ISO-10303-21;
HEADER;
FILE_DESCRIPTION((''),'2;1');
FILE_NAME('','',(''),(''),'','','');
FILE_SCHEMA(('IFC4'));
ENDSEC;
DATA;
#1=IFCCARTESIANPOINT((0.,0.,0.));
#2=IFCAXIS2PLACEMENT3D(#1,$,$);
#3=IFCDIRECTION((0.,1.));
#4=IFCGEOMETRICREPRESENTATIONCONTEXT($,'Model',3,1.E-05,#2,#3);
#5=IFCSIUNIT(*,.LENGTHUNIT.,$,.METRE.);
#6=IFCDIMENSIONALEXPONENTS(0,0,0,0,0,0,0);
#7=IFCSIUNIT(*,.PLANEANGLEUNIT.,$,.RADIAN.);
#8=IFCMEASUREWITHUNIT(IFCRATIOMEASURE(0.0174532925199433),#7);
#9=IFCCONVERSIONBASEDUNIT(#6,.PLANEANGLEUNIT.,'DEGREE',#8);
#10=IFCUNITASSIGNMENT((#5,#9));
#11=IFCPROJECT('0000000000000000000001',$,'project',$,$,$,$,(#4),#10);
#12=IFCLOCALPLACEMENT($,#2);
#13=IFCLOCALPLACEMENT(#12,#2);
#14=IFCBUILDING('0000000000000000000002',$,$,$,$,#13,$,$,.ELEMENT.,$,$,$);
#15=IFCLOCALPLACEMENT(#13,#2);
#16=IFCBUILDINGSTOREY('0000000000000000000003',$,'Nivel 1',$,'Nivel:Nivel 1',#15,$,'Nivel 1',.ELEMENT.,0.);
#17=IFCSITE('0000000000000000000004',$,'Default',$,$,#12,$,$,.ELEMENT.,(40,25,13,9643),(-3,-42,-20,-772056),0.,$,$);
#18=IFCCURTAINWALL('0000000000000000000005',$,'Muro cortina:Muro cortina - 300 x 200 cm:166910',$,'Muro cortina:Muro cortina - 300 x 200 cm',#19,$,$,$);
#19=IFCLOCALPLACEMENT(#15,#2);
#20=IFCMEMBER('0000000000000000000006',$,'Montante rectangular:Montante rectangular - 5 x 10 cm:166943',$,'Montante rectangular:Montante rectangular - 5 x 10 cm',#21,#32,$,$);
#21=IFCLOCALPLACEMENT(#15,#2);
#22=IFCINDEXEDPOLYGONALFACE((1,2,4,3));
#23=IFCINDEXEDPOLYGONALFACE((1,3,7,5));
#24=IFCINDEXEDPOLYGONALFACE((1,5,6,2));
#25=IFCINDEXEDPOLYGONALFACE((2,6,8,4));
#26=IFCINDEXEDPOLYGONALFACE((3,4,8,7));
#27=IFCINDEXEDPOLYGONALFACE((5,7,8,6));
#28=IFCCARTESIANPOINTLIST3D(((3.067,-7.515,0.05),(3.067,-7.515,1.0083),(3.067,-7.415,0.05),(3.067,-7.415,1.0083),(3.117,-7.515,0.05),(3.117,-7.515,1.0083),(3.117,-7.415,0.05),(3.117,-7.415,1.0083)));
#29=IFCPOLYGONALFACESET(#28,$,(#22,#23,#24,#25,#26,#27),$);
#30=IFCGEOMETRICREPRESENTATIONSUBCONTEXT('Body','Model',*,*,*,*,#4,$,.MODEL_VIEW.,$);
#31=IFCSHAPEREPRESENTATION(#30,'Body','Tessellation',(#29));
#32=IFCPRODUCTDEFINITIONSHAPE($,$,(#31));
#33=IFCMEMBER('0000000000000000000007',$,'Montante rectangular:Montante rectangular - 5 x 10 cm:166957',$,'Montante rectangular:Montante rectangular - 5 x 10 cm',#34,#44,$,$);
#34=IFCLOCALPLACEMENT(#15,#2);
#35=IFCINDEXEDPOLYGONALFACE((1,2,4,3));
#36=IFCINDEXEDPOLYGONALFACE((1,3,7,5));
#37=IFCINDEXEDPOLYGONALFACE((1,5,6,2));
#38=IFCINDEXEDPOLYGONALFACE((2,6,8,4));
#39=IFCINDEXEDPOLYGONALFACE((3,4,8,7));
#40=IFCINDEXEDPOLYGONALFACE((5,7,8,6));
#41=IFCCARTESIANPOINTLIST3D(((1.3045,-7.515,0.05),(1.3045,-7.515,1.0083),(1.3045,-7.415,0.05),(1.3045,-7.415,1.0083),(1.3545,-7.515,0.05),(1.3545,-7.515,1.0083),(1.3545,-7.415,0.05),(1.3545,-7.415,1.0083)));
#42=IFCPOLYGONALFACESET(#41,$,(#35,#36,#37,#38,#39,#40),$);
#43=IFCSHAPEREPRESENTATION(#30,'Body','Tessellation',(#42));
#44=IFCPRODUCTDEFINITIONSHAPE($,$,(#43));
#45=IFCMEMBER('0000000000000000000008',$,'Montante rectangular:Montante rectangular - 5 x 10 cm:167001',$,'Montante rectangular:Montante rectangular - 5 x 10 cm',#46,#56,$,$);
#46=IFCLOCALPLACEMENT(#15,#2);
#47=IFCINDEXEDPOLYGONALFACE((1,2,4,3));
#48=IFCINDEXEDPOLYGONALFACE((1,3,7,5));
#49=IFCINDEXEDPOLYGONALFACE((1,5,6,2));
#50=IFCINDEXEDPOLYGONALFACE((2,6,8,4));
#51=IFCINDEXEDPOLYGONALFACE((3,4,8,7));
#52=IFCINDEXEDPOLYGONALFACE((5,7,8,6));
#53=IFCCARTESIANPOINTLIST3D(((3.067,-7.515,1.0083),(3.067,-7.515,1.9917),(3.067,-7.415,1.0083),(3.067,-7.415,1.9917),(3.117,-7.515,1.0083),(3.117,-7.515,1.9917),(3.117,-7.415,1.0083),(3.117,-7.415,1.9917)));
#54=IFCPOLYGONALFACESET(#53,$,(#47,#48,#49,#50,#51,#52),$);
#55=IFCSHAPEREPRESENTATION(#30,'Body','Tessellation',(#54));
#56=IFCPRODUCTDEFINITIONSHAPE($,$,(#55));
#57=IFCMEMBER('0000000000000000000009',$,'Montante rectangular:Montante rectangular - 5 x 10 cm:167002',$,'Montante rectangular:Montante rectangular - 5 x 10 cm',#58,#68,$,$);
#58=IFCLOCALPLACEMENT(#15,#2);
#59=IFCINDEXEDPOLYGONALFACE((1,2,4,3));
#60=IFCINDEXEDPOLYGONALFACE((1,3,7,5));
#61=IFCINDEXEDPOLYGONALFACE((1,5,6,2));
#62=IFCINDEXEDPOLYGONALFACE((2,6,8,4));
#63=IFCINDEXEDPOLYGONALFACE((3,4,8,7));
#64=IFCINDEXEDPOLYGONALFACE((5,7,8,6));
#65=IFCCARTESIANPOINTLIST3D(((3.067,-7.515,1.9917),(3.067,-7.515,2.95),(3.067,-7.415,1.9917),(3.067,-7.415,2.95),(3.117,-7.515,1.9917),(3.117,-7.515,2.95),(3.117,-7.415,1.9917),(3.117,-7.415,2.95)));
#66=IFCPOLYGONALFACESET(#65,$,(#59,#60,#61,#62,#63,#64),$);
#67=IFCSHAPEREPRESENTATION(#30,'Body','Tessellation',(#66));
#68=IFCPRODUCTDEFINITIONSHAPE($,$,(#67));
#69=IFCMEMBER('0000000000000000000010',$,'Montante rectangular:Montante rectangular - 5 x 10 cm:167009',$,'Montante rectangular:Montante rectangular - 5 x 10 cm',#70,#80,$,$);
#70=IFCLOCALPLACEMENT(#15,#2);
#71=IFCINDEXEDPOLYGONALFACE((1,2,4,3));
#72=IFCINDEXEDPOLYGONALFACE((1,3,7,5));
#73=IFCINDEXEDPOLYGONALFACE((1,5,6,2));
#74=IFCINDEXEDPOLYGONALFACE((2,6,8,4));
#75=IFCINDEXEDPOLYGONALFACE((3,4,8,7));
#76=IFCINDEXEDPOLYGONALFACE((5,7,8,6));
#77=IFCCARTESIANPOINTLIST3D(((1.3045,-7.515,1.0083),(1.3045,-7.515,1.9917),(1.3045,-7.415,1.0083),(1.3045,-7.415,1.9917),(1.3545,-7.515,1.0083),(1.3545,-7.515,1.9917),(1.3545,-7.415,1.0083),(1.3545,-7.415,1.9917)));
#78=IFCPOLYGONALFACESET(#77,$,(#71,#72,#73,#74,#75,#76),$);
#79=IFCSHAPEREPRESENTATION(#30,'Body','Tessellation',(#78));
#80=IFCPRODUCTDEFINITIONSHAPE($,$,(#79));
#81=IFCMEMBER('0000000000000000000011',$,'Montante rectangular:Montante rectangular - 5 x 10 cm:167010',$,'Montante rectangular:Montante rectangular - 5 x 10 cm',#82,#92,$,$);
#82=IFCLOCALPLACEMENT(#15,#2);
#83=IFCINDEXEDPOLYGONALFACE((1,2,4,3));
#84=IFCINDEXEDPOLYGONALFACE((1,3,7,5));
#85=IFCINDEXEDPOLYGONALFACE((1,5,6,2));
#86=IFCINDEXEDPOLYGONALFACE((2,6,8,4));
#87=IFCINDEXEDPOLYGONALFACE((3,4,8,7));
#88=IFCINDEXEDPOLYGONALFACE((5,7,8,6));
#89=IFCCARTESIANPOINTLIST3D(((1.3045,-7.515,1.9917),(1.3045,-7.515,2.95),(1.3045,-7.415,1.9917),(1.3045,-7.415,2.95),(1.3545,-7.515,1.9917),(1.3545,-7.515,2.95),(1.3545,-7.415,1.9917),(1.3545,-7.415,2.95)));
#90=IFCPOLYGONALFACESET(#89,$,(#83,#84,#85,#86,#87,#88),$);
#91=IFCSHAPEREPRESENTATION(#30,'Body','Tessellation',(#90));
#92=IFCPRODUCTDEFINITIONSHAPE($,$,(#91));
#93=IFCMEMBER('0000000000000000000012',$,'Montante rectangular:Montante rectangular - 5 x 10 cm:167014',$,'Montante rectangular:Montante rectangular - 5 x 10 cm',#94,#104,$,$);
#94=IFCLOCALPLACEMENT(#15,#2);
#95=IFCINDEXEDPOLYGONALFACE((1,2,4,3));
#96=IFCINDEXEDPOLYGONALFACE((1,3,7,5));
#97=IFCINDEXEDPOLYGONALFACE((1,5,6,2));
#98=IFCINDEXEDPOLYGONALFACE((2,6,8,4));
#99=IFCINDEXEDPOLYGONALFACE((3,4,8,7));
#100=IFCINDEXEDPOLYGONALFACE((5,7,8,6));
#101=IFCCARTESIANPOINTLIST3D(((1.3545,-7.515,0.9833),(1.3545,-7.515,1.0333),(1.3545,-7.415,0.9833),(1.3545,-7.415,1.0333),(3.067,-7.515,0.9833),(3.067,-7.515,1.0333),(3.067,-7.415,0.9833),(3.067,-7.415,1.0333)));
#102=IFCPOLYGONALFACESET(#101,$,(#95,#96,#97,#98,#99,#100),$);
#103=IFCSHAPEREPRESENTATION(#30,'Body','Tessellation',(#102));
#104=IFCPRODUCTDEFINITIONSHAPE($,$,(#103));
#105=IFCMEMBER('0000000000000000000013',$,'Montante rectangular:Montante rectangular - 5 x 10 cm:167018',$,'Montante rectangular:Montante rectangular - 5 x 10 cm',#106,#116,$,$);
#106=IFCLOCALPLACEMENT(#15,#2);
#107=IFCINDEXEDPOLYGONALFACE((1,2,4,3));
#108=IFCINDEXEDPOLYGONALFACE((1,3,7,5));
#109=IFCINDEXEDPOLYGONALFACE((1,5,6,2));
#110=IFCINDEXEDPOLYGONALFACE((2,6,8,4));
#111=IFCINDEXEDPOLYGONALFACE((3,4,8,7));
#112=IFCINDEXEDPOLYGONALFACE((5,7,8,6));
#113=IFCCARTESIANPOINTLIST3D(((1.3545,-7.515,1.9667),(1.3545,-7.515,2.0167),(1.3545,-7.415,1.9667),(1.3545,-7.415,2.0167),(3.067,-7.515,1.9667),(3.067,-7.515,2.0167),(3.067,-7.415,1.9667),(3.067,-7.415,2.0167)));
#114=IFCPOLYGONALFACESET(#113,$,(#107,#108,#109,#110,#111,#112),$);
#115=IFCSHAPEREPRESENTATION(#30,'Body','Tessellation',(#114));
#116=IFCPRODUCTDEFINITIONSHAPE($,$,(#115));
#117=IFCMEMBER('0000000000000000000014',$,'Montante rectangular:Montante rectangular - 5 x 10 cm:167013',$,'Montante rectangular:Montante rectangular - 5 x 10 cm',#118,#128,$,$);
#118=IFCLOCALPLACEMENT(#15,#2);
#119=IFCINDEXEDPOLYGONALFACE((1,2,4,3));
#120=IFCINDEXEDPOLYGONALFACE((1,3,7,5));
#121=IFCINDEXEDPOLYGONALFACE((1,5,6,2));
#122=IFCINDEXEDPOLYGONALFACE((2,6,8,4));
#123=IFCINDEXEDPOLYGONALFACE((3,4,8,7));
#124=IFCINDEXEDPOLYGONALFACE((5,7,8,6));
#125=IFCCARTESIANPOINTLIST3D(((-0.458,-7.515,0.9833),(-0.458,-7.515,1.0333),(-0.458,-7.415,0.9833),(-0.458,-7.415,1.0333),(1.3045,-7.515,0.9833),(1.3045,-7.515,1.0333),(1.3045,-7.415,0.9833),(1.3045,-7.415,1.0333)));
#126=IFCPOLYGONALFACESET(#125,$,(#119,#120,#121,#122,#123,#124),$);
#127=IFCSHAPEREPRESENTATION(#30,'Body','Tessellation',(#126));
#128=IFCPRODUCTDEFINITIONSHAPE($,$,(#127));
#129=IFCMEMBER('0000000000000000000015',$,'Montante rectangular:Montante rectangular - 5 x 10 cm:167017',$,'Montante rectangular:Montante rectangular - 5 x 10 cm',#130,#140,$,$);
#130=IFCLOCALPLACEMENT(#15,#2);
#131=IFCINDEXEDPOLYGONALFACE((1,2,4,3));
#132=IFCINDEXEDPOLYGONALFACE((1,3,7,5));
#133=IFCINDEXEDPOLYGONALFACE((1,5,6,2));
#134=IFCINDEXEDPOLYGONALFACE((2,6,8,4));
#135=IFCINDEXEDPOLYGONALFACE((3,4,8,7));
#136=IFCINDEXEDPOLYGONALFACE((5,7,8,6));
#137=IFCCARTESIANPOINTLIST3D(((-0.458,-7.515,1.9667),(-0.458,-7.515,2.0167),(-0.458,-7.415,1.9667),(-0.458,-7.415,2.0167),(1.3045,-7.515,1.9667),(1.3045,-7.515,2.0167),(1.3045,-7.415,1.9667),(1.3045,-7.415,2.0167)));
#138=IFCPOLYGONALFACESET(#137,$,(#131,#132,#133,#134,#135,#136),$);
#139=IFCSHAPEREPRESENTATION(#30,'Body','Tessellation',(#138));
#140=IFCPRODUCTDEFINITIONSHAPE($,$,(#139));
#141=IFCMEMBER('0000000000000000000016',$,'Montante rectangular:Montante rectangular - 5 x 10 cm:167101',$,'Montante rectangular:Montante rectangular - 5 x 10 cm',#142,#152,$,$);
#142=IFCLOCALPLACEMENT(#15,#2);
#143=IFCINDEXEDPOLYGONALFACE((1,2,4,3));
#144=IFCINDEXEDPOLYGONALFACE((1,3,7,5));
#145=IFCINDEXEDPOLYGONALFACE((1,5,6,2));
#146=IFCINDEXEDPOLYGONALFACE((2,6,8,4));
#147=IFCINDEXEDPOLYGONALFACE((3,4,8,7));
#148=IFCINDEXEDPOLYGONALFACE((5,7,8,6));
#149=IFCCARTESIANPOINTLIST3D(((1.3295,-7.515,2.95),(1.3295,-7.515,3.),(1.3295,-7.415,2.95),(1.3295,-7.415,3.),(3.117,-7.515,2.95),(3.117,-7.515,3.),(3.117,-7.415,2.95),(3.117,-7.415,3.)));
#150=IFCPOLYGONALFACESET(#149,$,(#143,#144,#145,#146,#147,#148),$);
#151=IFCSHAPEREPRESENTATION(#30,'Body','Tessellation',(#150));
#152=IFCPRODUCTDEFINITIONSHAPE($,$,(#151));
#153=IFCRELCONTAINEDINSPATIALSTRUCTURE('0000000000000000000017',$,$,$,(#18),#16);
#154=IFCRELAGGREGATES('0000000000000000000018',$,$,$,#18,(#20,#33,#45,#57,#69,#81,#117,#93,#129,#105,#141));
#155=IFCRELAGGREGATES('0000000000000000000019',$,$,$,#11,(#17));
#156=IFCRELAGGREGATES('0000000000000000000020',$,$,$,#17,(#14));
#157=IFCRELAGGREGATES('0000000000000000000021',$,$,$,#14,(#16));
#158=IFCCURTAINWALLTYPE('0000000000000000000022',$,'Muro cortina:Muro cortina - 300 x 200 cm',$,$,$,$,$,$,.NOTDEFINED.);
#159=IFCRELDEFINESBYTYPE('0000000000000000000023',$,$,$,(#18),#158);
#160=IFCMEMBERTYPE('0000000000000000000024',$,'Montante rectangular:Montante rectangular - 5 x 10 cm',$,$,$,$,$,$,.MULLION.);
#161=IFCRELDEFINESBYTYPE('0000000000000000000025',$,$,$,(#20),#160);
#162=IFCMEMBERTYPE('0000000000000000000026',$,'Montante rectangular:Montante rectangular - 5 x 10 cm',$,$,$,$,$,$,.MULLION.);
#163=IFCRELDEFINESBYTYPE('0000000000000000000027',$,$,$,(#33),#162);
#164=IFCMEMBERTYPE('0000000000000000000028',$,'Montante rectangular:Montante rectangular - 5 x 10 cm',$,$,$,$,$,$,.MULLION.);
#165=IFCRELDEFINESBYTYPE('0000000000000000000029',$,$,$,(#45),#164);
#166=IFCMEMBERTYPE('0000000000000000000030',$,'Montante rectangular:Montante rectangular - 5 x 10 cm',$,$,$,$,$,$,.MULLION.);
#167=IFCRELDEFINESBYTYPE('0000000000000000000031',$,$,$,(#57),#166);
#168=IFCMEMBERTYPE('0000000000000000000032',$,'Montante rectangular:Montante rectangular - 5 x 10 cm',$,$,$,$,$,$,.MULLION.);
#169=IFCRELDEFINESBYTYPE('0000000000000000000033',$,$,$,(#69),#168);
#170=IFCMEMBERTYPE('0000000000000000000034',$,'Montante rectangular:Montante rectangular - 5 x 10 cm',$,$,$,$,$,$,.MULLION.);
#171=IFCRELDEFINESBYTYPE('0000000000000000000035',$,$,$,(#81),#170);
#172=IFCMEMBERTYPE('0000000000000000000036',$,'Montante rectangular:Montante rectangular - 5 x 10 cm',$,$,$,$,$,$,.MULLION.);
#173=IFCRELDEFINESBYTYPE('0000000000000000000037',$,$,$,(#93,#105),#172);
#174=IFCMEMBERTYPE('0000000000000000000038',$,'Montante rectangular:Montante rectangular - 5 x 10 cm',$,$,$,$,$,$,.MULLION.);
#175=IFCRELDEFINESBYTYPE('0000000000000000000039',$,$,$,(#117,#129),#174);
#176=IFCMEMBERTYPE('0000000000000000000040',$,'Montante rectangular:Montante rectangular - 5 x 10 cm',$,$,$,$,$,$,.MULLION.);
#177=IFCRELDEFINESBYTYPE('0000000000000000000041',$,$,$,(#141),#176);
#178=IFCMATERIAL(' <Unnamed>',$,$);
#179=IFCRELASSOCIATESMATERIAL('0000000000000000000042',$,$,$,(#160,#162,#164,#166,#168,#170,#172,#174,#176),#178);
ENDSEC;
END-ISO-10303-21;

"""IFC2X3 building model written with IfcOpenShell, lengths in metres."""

from ifc_helpers import new_model, entity, si_unit, converted_unit, direction, frame, origin, origin_2d_with_axis, place, context, subcontext, project, spatial, rectangle, extrude, source, transform, mapped, material, type_object, type_shapes, element, aggregate, save


model = new_model("IFC2X3")

# Units and contexts
model_context = context("Model", 3, precision=1e-05, world=origin(), true_north=direction((0.0, 1.0)))
body_context = subcontext(model_context, "Body", "Model", "MODEL_VIEW")
ifc_project = project(units=[si_unit("LENGTHUNIT", "METRE"), converted_unit("PLANEANGLEUNIT", "DEGREE", entity("IfcRatioMeasure", 0.0174532925199433), si_unit("PLANEANGLEUNIT", "RADIAN"), dimensions=[0, 0, 0, 0, 0, 0, 0])], contexts=[model_context])

# Site, building, storey
site_placement = place(None, origin())
site = spatial("IfcSite", under=ifc_project, at=site_placement, Name="Default", CompositionType="ELEMENT", RefLatitude=(40, 25, 13, 9643), RefLongitude=(-3, -42, -20, -772056), RefElevation=0.0)
building_placement = place(site_placement, origin())
building = spatial("IfcBuilding", under=site, at=building_placement, CompositionType="ELEMENT")
storey_placement = place(building_placement, origin())
storey = spatial("IfcBuildingStorey", under=building, at=storey_placement, Name="Nivel 1", ObjectType="Nivel:Nivel 1", LongName="Nivel 1", CompositionType="ELEMENT", Elevation=0.0)

# Curtain wall, members
curtain_wall_type = type_object("IfcCurtainWallType", Name="Muro cortina:Muro cortina - 300 x 200 cm", PredefinedType="NOTDEFINED")
curtain_wall_placement = place(storey_placement, origin())
curtain_wall = element("IfcCurtainWall", 1, at=curtain_wall_placement, inside=storey, type_object=curtain_wall_type, Name="Muro cortina:Muro cortina - 300 x 200 cm:166910", ObjectType="Muro cortina:Muro cortina - 300 x 200 cm")
ifc_material_1 = material(Name=" <Unnamed>")
member_type_1 = type_object("IfcMemberType", Name="Montante rectangular:Montante rectangular - 5 x 10 cm", PredefinedType="MULLION", material=ifc_material_1)
shared_shape_1 = source(origin(), body_context, "Body", "SweptSolid", [
    extrude(rectangle(XDim=0.1, YDim=0.05, at=origin_2d_with_axis()), frame((-0.025, 0.0, -0.9583), z_axis=(0.0, 0.0, 1.0), x_axis=(0.0, -1.0, 0.0)), (0.0, 0.0, 1.0), 0.9583),
])
type_shapes(member_type_1, [shared_shape_1])
member_1_placement = place(storey_placement, frame((3.117, -7.465, 0.05), z_axis=(0.0, 0.0, -1.0), x_axis=(1.0, 0.0, 0.0)))
member_1 = element("IfcMember", 2, at=member_1_placement, type_object=member_type_1, Name="Montante rectangular:Montante rectangular - 5 x 10 cm:166943", ObjectType="Montante rectangular:Montante rectangular - 5 x 10 cm", context=body_context, shape_type="MappedRepresentation", body=[
    mapped(shared_shape_1, transform((0.0, 0.0, 0.0), scale=1.0)),
])
member_type_2 = type_object("IfcMemberType", Name="Montante rectangular:Montante rectangular - 5 x 10 cm", PredefinedType="MULLION", material=ifc_material_1)
shared_shape_2 = source(origin(), body_context, "Body", "SweptSolid", [
    extrude(rectangle(XDim=0.1, YDim=0.05, at=origin_2d_with_axis()), frame((0.0, 0.0, -0.9583), z_axis=(0.0, 0.0, 1.0), x_axis=(0.0, -1.0, 0.0)), (0.0, 0.0, 1.0), 0.9583),
])
type_shapes(member_type_2, [shared_shape_2])
member_2_placement = place(storey_placement, frame((1.3295, -7.465, 0.05), z_axis=(0.0, 0.0, -1.0), x_axis=(1.0, 0.0, 0.0)))
member_2 = element("IfcMember", 3, at=member_2_placement, type_object=member_type_2, Name="Montante rectangular:Montante rectangular - 5 x 10 cm:166957", ObjectType="Montante rectangular:Montante rectangular - 5 x 10 cm", context=body_context, shape_type="MappedRepresentation", body=[
    mapped(shared_shape_2, transform((0.0, 0.0, 0.0), scale=1.0)),
])
member_type_3 = type_object("IfcMemberType", Name="Montante rectangular:Montante rectangular - 5 x 10 cm", PredefinedType="MULLION", material=ifc_material_1)
shared_shape_3 = source(origin(), body_context, "Body", "SweptSolid", [
    extrude(rectangle(XDim=0.1, YDim=0.05, at=origin_2d_with_axis()), frame((-0.025, 0.0, -0.9833), z_axis=(0.0, 0.0, 1.0), x_axis=(0.0, -1.0, 0.0)), (0.0, 0.0, 1.0), 0.9833),
])
type_shapes(member_type_3, [shared_shape_3])
member_3_placement = place(storey_placement, frame((3.117, -7.465, 1.0083), z_axis=(0.0, 0.0, -1.0), x_axis=(1.0, 0.0, 0.0)))
member_3 = element("IfcMember", 4, at=member_3_placement, type_object=member_type_3, Name="Montante rectangular:Montante rectangular - 5 x 10 cm:167001", ObjectType="Montante rectangular:Montante rectangular - 5 x 10 cm", context=body_context, shape_type="MappedRepresentation", body=[
    mapped(shared_shape_3, transform((0.0, 0.0, 0.0), scale=1.0)),
])
member_type_4 = type_object("IfcMemberType", Name="Montante rectangular:Montante rectangular - 5 x 10 cm", PredefinedType="MULLION", material=ifc_material_1)
shared_shape_4 = source(origin(), body_context, "Body", "SweptSolid", [
    extrude(rectangle(XDim=0.1, YDim=0.05, at=origin_2d_with_axis()), frame((-0.025, 0.0, -0.9583), z_axis=(0.0, 0.0, 1.0), x_axis=(0.0, -1.0, 0.0)), (0.0, 0.0, 1.0), 0.9583),
])
type_shapes(member_type_4, [shared_shape_4])
member_4_placement = place(storey_placement, frame((3.117, -7.465, 1.9917), z_axis=(0.0, 0.0, -1.0), x_axis=(1.0, 0.0, 0.0)))
member_4 = element("IfcMember", 5, at=member_4_placement, type_object=member_type_4, Name="Montante rectangular:Montante rectangular - 5 x 10 cm:167002", ObjectType="Montante rectangular:Montante rectangular - 5 x 10 cm", context=body_context, shape_type="MappedRepresentation", body=[
    mapped(shared_shape_4, transform((0.0, 0.0, 0.0), scale=1.0)),
])
member_type_5 = type_object("IfcMemberType", Name="Montante rectangular:Montante rectangular - 5 x 10 cm", PredefinedType="MULLION", material=ifc_material_1)
shared_shape_5 = source(origin(), body_context, "Body", "SweptSolid", [
    extrude(rectangle(XDim=0.1, YDim=0.05, at=origin_2d_with_axis()), frame((0.0, 0.0, -0.9833), z_axis=(0.0, 0.0, 1.0), x_axis=(0.0, -1.0, 0.0)), (0.0, 0.0, 1.0), 0.9833),
])
type_shapes(member_type_5, [shared_shape_5])
member_5_placement = place(storey_placement, frame((1.3295, -7.465, 1.0083), z_axis=(0.0, 0.0, -1.0), x_axis=(1.0, 0.0, 0.0)))
member_5 = element("IfcMember", 6, at=member_5_placement, type_object=member_type_5, Name="Montante rectangular:Montante rectangular - 5 x 10 cm:167009", ObjectType="Montante rectangular:Montante rectangular - 5 x 10 cm", context=body_context, shape_type="MappedRepresentation", body=[
    mapped(shared_shape_5, transform((0.0, 0.0, 0.0), scale=1.0)),
])
member_type_6 = type_object("IfcMemberType", Name="Montante rectangular:Montante rectangular - 5 x 10 cm", PredefinedType="MULLION", material=ifc_material_1)
shared_shape_6 = source(origin(), body_context, "Body", "SweptSolid", [
    extrude(rectangle(XDim=0.1, YDim=0.05, at=origin_2d_with_axis()), frame((0.0, 0.0, -0.9583), z_axis=(0.0, 0.0, 1.0), x_axis=(0.0, -1.0, 0.0)), (0.0, 0.0, 1.0), 0.9583),
])
type_shapes(member_type_6, [shared_shape_6])
member_6_placement = place(storey_placement, frame((1.3295, -7.465, 1.9917), z_axis=(0.0, 0.0, -1.0), x_axis=(1.0, 0.0, 0.0)))
member_6 = element("IfcMember", 7, at=member_6_placement, type_object=member_type_6, Name="Montante rectangular:Montante rectangular - 5 x 10 cm:167010", ObjectType="Montante rectangular:Montante rectangular - 5 x 10 cm", context=body_context, shape_type="MappedRepresentation", body=[
    mapped(shared_shape_6, transform((0.0, 0.0, 0.0), scale=1.0)),
])
member_type_7 = type_object("IfcMemberType", Name="Montante rectangular:Montante rectangular - 5 x 10 cm", PredefinedType="MULLION", material=ifc_material_1)
shared_shape_7 = source(origin(), body_context, "Body", "SweptSolid", [
    extrude(rectangle(XDim=0.1, YDim=0.05, at=origin_2d_with_axis()), frame((0.0, 0.0, -1.7125), z_axis=(0.0, 0.0, 1.0), x_axis=(0.0, -1.0, 0.0)), (0.0, 0.0, 1.0), 1.7125),
])
type_shapes(member_type_7, [shared_shape_7])
member_7_placement = place(storey_placement, frame((3.067, -7.465, 1.0083), z_axis=(1.0, 0.0, 0.0), x_axis=(0.0, 0.0, 1.0)))
member_7 = element("IfcMember", 8, at=member_7_placement, type_object=member_type_7, Name="Montante rectangular:Montante rectangular - 5 x 10 cm:167014", ObjectType="Montante rectangular:Montante rectangular - 5 x 10 cm", context=body_context, shape_type="MappedRepresentation", body=[
    mapped(shared_shape_7, transform((0.0, 0.0, 0.0), scale=1.0)),
])
member_8_placement = place(storey_placement, frame((3.067, -7.465, 1.9917), z_axis=(1.0, 0.0, 0.0), x_axis=(0.0, 0.0, 1.0)))
member_8 = element("IfcMember", 9, at=member_8_placement, type_object=member_type_7, Name="Montante rectangular:Montante rectangular - 5 x 10 cm:167018", ObjectType="Montante rectangular:Montante rectangular - 5 x 10 cm", context=body_context, shape_type="MappedRepresentation", body=[
    mapped(shared_shape_7, transform((0.0, 0.0, 0.0), scale=1.0)),
])
member_type_8 = type_object("IfcMemberType", Name="Montante rectangular:Montante rectangular - 5 x 10 cm", PredefinedType="MULLION", material=ifc_material_1)
shared_shape_8 = source(origin(), body_context, "Body", "SweptSolid", [
    extrude(rectangle(XDim=0.1, YDim=0.05, at=origin_2d_with_axis()), frame((0.0, 0.0, -1.7625), z_axis=(0.0, 0.0, 1.0), x_axis=(0.0, -1.0, 0.0)), (0.0, 0.0, 1.0), 1.7625),
])
type_shapes(member_type_8, [shared_shape_8])
member_9_placement = place(storey_placement, frame((1.3045, -7.465, 1.0083), z_axis=(1.0, 0.0, 0.0), x_axis=(0.0, 0.0, 1.0)))
member_9 = element("IfcMember", 10, at=member_9_placement, type_object=member_type_8, Name="Montante rectangular:Montante rectangular - 5 x 10 cm:167013", ObjectType="Montante rectangular:Montante rectangular - 5 x 10 cm", context=body_context, shape_type="MappedRepresentation", body=[
    mapped(shared_shape_8, transform((0.0, 0.0, 0.0), scale=1.0)),
])
member_10_placement = place(storey_placement, frame((1.3045, -7.465, 1.9917), z_axis=(1.0, 0.0, 0.0), x_axis=(0.0, 0.0, 1.0)))
member_10 = element("IfcMember", 11, at=member_10_placement, type_object=member_type_8, Name="Montante rectangular:Montante rectangular - 5 x 10 cm:167017", ObjectType="Montante rectangular:Montante rectangular - 5 x 10 cm", context=body_context, shape_type="MappedRepresentation", body=[
    mapped(shared_shape_8, transform((0.0, 0.0, 0.0), scale=1.0)),
])
member_type_9 = type_object("IfcMemberType", Name="Montante rectangular:Montante rectangular - 5 x 10 cm", PredefinedType="MULLION", material=ifc_material_1)
shared_shape_9 = source(origin(), body_context, "Body", "SweptSolid", [
    extrude(rectangle(XDim=0.1, YDim=0.05, at=origin_2d_with_axis()), frame((-0.025, 0.0, -1.7875), z_axis=(0.0, 0.0, 1.0), x_axis=(0.0, -1.0, 0.0)), (0.0, 0.0, 1.0), 1.7875),
])
type_shapes(member_type_9, [shared_shape_9])
member_11_placement = place(storey_placement, frame((3.117, -7.465, 3.0), z_axis=(1.0, 0.0, 0.0), x_axis=(0.0, 0.0, 1.0)))
member_11 = element("IfcMember", 12, at=member_11_placement, type_object=member_type_9, Name="Montante rectangular:Montante rectangular - 5 x 10 cm:167101", ObjectType="Montante rectangular:Montante rectangular - 5 x 10 cm", context=body_context, shape_type="MappedRepresentation", body=[
    mapped(shared_shape_9, transform((0.0, 0.0, 0.0), scale=1.0)),
])
aggregate(curtain_wall, [member_1, member_2, member_3, member_4, member_5, member_6, member_9, member_7, member_10, member_8, member_11])

save(model, "model.ifc")
